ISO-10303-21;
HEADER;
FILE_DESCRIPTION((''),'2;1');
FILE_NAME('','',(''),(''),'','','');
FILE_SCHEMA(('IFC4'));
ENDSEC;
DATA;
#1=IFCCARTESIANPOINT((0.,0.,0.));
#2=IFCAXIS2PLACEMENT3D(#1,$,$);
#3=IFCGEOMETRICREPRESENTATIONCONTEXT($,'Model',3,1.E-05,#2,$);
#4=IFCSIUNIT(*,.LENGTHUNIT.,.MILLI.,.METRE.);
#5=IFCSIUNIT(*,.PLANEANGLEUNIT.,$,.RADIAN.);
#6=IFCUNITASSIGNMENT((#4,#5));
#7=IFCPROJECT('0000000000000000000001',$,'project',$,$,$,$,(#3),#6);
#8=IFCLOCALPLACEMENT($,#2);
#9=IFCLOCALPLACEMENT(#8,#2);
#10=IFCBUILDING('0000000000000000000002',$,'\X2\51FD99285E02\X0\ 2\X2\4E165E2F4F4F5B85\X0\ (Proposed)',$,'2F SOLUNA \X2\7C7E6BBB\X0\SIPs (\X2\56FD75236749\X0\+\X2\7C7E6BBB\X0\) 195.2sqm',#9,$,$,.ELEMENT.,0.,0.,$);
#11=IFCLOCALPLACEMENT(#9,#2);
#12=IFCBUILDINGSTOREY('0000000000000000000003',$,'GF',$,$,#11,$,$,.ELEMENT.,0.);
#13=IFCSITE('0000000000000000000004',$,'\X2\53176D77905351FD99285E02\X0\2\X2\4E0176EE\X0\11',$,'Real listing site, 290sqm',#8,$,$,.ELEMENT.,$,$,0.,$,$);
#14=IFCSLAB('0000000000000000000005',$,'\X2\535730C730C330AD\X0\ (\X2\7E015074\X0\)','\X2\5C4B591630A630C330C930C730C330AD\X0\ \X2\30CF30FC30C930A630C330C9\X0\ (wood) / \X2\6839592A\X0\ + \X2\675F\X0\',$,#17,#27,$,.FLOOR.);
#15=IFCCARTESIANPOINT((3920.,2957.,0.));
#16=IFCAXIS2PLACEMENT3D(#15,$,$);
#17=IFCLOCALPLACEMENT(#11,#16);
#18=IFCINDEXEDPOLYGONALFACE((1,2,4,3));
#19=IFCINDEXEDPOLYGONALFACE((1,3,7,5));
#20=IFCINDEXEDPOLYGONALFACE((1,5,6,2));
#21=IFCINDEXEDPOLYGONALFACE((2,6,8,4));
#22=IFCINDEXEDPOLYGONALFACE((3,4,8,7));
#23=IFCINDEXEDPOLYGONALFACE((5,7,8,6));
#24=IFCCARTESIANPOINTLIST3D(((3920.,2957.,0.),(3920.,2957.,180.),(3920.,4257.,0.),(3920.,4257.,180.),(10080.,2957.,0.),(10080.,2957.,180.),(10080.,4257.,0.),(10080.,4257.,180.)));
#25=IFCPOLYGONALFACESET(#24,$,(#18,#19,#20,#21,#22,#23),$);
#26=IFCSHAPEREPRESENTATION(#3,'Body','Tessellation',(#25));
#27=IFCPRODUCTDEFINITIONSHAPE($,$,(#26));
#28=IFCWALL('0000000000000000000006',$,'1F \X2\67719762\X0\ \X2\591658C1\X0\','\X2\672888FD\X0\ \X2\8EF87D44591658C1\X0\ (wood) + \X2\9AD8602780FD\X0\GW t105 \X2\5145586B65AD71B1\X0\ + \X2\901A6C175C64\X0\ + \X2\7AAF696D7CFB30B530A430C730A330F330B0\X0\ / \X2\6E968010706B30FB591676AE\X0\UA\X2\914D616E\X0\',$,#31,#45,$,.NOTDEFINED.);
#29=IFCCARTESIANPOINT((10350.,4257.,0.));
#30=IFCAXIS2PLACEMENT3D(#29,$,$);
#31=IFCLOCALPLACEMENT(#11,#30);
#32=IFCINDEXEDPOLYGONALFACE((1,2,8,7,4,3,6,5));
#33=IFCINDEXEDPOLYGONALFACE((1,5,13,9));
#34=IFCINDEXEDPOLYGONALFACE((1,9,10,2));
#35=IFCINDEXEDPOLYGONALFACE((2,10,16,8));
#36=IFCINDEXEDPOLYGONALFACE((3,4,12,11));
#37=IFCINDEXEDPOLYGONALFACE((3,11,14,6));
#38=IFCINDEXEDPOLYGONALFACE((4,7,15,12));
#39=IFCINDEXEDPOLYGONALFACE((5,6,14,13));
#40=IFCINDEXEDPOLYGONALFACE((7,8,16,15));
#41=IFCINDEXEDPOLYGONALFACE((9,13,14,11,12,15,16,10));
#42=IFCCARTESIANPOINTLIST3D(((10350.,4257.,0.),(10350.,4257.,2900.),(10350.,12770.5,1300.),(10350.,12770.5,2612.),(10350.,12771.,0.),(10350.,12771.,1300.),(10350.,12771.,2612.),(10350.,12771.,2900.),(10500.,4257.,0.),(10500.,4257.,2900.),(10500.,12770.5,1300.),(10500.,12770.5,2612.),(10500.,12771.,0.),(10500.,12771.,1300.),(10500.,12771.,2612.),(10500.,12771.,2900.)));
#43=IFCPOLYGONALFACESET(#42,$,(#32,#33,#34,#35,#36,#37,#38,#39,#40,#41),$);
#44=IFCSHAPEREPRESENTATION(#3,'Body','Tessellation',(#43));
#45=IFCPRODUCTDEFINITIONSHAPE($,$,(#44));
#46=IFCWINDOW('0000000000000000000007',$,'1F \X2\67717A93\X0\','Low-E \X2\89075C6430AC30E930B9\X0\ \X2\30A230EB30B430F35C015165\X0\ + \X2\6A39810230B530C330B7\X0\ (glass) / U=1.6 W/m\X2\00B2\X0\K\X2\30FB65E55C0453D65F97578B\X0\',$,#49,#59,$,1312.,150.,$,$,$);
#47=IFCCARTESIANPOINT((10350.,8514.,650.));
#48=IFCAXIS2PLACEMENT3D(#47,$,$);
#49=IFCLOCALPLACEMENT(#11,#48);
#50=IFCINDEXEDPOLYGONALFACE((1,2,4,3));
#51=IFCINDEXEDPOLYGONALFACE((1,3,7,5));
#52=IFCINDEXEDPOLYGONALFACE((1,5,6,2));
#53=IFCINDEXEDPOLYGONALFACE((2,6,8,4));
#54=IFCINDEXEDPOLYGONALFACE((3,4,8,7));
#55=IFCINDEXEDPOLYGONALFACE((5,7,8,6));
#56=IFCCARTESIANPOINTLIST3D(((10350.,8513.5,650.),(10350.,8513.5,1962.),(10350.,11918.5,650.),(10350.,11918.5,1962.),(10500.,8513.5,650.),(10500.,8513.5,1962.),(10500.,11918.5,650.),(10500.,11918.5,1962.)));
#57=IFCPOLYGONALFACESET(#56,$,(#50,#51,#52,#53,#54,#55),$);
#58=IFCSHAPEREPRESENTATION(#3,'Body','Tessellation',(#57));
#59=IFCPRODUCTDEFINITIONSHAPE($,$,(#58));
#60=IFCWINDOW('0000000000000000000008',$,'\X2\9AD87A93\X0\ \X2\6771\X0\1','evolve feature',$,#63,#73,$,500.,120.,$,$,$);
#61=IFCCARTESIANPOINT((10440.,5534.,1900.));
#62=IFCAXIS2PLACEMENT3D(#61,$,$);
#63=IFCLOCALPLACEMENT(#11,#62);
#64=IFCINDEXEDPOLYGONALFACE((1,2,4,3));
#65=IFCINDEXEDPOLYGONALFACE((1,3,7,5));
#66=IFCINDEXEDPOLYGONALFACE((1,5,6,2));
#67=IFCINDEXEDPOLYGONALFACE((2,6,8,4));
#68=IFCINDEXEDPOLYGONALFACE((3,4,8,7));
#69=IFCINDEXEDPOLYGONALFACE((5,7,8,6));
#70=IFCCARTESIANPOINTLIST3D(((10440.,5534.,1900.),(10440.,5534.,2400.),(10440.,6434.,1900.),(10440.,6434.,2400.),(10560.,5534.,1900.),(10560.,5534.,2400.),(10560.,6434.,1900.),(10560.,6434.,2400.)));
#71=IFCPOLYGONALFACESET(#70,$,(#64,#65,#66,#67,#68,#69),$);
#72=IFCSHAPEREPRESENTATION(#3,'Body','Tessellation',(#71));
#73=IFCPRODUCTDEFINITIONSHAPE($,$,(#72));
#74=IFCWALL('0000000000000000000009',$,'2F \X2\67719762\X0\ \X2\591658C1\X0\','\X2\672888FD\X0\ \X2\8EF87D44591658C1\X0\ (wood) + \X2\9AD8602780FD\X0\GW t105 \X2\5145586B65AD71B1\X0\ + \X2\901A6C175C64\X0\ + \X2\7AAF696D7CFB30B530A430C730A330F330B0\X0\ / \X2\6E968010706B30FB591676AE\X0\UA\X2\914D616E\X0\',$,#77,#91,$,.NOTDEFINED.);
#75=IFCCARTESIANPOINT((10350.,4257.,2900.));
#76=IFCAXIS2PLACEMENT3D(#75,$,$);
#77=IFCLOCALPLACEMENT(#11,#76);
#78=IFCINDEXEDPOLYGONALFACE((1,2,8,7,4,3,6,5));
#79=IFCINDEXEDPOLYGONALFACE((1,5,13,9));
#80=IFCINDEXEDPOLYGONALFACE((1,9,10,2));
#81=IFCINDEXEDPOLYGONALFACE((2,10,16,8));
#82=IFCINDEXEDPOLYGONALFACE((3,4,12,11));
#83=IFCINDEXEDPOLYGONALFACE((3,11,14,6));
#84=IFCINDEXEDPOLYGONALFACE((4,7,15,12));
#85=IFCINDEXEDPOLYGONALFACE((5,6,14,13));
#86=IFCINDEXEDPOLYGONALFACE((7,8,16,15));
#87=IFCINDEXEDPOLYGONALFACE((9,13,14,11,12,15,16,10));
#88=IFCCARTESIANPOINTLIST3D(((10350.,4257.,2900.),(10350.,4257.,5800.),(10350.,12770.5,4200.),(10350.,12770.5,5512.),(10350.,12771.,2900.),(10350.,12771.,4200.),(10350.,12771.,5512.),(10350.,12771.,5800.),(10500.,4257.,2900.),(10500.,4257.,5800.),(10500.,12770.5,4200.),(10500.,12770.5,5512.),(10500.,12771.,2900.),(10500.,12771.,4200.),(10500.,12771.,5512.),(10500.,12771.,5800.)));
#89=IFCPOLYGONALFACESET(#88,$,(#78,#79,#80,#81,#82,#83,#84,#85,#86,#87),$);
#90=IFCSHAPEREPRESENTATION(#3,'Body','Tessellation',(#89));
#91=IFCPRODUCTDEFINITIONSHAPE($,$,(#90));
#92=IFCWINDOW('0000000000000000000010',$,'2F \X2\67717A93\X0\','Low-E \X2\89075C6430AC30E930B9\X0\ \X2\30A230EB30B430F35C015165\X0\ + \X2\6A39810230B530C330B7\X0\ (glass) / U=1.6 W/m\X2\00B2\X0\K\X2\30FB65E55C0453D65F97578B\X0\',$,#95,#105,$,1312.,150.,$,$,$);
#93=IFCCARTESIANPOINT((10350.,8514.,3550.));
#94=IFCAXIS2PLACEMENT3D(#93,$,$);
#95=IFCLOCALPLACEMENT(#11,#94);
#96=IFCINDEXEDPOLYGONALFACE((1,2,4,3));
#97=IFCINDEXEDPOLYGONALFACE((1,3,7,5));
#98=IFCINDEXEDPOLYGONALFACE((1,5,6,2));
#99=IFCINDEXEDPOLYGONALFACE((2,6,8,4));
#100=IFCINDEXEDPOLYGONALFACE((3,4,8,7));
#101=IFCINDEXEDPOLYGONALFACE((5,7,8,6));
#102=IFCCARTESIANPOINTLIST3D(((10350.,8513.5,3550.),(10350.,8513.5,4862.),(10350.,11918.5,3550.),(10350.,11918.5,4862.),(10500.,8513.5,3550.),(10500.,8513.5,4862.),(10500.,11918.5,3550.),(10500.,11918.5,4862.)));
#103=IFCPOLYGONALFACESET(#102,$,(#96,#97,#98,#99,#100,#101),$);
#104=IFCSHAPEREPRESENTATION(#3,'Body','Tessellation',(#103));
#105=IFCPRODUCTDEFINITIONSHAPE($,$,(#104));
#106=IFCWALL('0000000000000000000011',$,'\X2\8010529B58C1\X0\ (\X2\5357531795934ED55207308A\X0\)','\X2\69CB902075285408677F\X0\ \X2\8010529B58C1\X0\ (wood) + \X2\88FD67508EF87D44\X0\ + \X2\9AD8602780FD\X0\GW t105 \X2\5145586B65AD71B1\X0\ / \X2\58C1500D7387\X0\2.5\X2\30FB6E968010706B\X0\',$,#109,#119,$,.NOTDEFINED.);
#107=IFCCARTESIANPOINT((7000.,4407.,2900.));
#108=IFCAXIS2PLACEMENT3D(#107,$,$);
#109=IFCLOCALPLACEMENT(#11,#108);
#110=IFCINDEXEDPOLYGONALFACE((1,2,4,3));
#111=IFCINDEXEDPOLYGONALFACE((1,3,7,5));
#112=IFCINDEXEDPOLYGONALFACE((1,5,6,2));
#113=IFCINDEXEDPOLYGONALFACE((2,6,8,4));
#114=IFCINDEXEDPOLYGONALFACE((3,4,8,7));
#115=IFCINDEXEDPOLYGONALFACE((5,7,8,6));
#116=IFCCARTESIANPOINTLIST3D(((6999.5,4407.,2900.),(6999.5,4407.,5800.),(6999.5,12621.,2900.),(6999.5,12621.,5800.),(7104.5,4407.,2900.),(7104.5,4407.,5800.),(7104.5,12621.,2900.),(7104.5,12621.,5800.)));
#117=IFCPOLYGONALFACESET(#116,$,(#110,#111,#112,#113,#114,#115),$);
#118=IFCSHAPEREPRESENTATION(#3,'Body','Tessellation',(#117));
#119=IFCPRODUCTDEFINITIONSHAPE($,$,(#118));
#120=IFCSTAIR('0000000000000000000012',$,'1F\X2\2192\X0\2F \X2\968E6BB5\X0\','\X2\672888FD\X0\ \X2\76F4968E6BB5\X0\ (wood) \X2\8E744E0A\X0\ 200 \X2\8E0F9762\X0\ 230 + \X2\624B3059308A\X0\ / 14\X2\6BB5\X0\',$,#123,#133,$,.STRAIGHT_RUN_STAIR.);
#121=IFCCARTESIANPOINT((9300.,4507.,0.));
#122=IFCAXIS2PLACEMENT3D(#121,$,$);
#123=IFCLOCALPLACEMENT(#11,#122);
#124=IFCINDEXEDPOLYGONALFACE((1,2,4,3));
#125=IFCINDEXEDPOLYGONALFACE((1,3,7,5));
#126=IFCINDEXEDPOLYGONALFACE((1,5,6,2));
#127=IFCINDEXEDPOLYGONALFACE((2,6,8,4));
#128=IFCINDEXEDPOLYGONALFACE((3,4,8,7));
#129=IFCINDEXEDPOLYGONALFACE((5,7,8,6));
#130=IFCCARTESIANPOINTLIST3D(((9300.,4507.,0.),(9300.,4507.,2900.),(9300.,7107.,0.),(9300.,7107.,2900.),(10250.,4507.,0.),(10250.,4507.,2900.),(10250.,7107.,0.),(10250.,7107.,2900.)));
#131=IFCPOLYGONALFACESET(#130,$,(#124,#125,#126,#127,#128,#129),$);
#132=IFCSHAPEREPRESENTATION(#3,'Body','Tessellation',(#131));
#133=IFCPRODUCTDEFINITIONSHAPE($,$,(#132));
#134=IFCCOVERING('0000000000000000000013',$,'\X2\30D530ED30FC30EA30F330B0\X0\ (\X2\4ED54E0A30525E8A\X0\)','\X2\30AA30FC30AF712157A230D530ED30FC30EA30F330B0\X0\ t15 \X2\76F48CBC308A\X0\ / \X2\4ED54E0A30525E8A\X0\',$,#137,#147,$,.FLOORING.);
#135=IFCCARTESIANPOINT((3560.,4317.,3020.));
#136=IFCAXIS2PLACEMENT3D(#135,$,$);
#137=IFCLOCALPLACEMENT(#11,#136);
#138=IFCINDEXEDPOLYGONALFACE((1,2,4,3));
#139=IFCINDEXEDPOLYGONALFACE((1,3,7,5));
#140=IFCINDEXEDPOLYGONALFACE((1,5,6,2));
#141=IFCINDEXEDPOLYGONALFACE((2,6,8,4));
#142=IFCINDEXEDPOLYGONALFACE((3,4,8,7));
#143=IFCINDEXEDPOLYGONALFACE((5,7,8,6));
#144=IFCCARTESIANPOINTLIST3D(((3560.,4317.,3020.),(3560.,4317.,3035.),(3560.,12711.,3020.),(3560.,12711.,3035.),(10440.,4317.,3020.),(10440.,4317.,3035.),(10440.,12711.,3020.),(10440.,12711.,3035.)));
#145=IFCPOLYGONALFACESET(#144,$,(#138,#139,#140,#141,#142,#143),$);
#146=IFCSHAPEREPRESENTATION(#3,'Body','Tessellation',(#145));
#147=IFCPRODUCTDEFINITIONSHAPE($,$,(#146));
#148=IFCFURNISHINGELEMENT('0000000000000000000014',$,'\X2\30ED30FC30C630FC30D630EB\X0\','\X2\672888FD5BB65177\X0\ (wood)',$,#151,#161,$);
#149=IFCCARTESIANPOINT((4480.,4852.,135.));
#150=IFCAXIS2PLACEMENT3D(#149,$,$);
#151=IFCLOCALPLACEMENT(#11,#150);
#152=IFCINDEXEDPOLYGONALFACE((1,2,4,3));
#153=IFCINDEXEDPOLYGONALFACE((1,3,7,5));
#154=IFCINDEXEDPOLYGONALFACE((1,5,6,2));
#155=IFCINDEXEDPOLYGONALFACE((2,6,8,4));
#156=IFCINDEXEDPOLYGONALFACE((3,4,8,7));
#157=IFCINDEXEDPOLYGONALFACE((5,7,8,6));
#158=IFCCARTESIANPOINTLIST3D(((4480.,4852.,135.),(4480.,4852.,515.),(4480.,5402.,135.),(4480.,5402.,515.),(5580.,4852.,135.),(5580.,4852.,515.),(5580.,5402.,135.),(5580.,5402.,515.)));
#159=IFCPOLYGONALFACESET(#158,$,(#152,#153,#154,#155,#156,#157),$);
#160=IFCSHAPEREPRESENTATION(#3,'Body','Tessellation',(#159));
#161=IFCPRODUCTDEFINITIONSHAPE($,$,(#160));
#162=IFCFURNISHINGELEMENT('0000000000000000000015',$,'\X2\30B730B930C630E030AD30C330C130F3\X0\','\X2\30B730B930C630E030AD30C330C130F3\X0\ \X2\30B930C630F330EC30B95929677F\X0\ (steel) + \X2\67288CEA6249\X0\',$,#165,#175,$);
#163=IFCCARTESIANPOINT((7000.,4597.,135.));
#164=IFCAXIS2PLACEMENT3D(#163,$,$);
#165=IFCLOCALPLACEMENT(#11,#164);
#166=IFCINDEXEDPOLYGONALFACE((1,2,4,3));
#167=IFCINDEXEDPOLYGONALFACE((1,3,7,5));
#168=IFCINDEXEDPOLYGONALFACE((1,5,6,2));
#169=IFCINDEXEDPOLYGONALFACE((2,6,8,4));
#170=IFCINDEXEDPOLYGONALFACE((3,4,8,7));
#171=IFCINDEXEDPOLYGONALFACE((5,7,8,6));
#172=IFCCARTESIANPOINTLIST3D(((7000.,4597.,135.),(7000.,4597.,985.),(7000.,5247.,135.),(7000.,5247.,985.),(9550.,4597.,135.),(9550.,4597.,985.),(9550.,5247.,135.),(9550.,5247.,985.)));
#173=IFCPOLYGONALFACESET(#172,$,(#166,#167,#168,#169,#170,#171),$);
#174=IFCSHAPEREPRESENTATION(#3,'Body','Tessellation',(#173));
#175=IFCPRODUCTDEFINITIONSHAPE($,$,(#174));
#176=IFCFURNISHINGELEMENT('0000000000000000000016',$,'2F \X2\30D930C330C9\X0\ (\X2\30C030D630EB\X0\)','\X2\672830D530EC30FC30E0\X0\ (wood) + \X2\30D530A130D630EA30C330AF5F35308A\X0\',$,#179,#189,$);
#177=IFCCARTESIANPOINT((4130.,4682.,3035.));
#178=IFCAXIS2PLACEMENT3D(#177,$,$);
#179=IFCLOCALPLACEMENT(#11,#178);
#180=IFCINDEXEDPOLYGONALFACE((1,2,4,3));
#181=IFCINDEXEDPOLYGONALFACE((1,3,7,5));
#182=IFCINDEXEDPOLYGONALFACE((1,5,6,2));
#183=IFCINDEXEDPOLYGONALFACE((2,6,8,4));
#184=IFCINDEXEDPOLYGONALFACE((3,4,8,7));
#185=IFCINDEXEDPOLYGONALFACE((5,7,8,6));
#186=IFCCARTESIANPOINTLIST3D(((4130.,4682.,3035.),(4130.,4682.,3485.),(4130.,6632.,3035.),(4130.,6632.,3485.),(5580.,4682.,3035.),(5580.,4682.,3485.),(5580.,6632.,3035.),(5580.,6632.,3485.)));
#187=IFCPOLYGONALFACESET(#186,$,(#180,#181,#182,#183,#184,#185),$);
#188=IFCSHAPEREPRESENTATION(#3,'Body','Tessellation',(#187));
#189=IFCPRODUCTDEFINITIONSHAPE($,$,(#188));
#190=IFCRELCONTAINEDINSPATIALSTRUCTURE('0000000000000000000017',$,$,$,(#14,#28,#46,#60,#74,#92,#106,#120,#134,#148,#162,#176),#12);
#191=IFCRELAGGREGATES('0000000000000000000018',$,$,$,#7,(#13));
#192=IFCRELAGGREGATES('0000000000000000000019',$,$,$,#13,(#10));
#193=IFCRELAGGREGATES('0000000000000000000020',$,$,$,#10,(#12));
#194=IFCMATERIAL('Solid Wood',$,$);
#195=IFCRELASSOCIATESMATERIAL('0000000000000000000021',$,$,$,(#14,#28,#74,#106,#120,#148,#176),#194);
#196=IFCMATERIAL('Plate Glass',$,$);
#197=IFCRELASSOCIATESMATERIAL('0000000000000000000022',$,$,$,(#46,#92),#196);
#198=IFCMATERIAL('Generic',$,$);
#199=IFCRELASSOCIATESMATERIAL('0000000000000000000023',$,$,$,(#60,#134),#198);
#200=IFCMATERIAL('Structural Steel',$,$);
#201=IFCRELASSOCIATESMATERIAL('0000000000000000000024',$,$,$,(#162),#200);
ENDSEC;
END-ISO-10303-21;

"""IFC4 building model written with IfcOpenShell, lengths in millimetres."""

from ifc_helpers import new_model, si_unit, frame, frame_2d, origin, place, context, project, spatial, rectangle, extrude, material, element, fill, save


model = new_model("IFC4")

# Units and contexts
model_context = context("Model", 3, precision=1e-05, world=origin())
ifc_project = project(units=[si_unit("LENGTHUNIT", "METRE", prefix="MILLI"), si_unit("PLANEANGLEUNIT", "RADIAN")], contexts=[model_context])

# Site, building, storey
site_placement = place(None, origin())
site = spatial("IfcSite", under=ifc_project, at=site_placement, Name="北海道函館市2丁目11", ObjectType="Real listing site, 290sqm", CompositionType="ELEMENT", RefElevation=0.0)
building_placement = place(site_placement, origin())
building = spatial("IfcBuilding", under=site, at=building_placement, Name="函館市 2世帯住宅 (Proposed)", ObjectType="2F SOLUNA 籾殻SIPs (国産杉+籾殻) 195.2sqm", CompositionType="ELEMENT", ElevationOfRefHeight=0.0, ElevationOfTerrain=0.0)
storey_placement = place(building_placement, origin())
storey = spatial("IfcBuildingStorey", under=building, at=storey_placement, Name="GF", CompositionType="ELEMENT", Elevation=0.0)

# Slab
ifc_material_1 = material(Name="Solid Wood")
slab_placement = place(storey_placement, frame((3920.0, 2957.0, 0.0)))
element("IfcSlab", 1, at=slab_placement, inside=storey, material=ifc_material_1, Name="南デッキ (縁側)", Description="屋外ウッドデッキ ハードウッド (wood) / 根太 + 束", PredefinedType="FLOOR", context=model_context, shape_type="SweptSolid", body=[
    extrude(rectangle(XDim=6160.0, YDim=1300.0, at=frame_2d((3080.0, 650.0))), frame((3920.0, 2957.0, 0.0)), (0.0, 0.0, 1.0), 180.0),
])

# Wall, openings, windows
wall_1_placement = place(storey_placement, frame((10350.0, 4257.0, 0.0)))
wall_1 = element("IfcWall", 2, at=wall_1_placement, inside=storey, material=ifc_material_1, Name="1F 東面 外壁", Description="木製 軸組外壁 (wood) + 高性能GW t105 充填断熱 + 通気層 + 窯業系サイディング / 準耐火・外皮UA配慮", PredefinedType="NOTDEFINED", context=model_context, shape_type="SweptSolid", body=[
    extrude(rectangle(XDim=150.0, YDim=8514.0, at=frame_2d((75.0, 4257.0))), frame((10350.0, 4257.0, 0.0)), (0.0, 0.0, 1.0), 2900.0),
])
opening_1_placement = place(storey_placement, frame((10350.0, 8514.0, 650.0)))
opening_1 = element("IfcOpeningElement", 3, at=opening_1_placement, cuts=wall_1, PredefinedType="NOTDEFINED", context=model_context, shape_type="SweptSolid", body=[
    extrude(rectangle(XDim=150.0, YDim=3405.0, at=frame_2d((75.0, 1702.0))), frame((10350.0, 8514.0, 650.0)), (0.0, 0.0, 1.0), 1312.0),
])
opening_2_placement = place(storey_placement, frame((10440.0, 5534.0, 1900.0)))
opening_2 = element("IfcOpeningElement", 4, at=opening_2_placement, cuts=wall_1, PredefinedType="NOTDEFINED", context=model_context, shape_type="SweptSolid", body=[
    extrude(rectangle(XDim=120.0, YDim=900.0, at=frame_2d((60.0, 450.0))), frame((10440.0, 5534.0, 1900.0)), (0.0, 0.0, 1.0), 500.0),
])
ifc_material_2 = material(Name="Plate Glass")
window_1_placement = place(storey_placement, frame((10350.0, 8514.0, 650.0)))
window_1 = element("IfcWindow", 5, at=window_1_placement, inside=storey, material=ifc_material_2, Name="1F 東窓", Description="Low-E 複層ガラス アルゴン封入 + 樹脂サッシ (glass) / U=1.6 W/m²K・日射取得型", OverallHeight=1312.0, OverallWidth=150.0, context=model_context, shape_type="SweptSolid", body=[
    extrude(rectangle(XDim=150.0, YDim=3405.0, at=frame_2d((75.0, 1702.0))), frame((10350.0, 8514.0, 650.0)), (0.0, 0.0, 1.0), 1312.0),
])
fill(opening_1, window_1)
ifc_material_3 = material(Name="Generic")
window_2_placement = place(storey_placement, frame((10440.0, 5534.0, 1900.0)))
window_2 = element("IfcWindow", 6, at=window_2_placement, inside=storey, material=ifc_material_3, Name="高窓 東1", Description="evolve feature", OverallHeight=500.0, OverallWidth=120.0, context=model_context, shape_type="SweptSolid", body=[
    extrude(rectangle(XDim=120.0, YDim=900.0, at=frame_2d((60.0, 450.0))), frame((10440.0, 5534.0, 1900.0)), (0.0, 0.0, 1.0), 500.0),
])
fill(opening_2, window_2)

# Wall, opening, window
wall_2_placement = place(storey_placement, frame((10350.0, 4257.0, 2900.0)))
wall_2 = element("IfcWall", 7, at=wall_2_placement, inside=storey, material=ifc_material_1, Name="2F 東面 外壁", Description="木製 軸組外壁 (wood) + 高性能GW t105 充填断熱 + 通気層 + 窯業系サイディング / 準耐火・外皮UA配慮", PredefinedType="NOTDEFINED", context=model_context, shape_type="SweptSolid", body=[
    extrude(rectangle(XDim=150.0, YDim=8514.0, at=frame_2d((75.0, 4257.0))), frame((10350.0, 4257.0, 2900.0)), (0.0, 0.0, 1.0), 2900.0),
])
opening_3_placement = place(storey_placement, frame((10350.0, 8514.0, 3550.0)))
opening_3 = element("IfcOpeningElement", 8, at=opening_3_placement, cuts=wall_2, PredefinedType="NOTDEFINED", context=model_context, shape_type="SweptSolid", body=[
    extrude(rectangle(XDim=150.0, YDim=3405.0, at=frame_2d((75.0, 1702.0))), frame((10350.0, 8514.0, 3550.0)), (0.0, 0.0, 1.0), 1312.0),
])
window_3_placement = place(storey_placement, frame((10350.0, 8514.0, 3550.0)))
window_3 = element("IfcWindow", 9, at=window_3_placement, inside=storey, material=ifc_material_2, Name="2F 東窓", Description="Low-E 複層ガラス アルゴン封入 + 樹脂サッシ (glass) / U=1.6 W/m²K・日射取得型", OverallHeight=1312.0, OverallWidth=150.0, context=model_context, shape_type="SweptSolid", body=[
    extrude(rectangle(XDim=150.0, YDim=3405.0, at=frame_2d((75.0, 1702.0))), frame((10350.0, 8514.0, 3550.0)), (0.0, 0.0, 1.0), 1312.0),
])
fill(opening_3, window_3)

# Wall
wall_3_placement = place(storey_placement, frame((7000.0, 4407.0, 2900.0)))
element("IfcWall", 10, at=wall_3_placement, inside=storey, material=ifc_material_1, Name="耐力壁 (南北間仕切り)", Description="構造用合板 耐力壁 (wood) + 製材軸組 + 高性能GW t105 充填断熱 / 壁倍率2.5・準耐火", PredefinedType="NOTDEFINED", context=model_context, shape_type="SweptSolid", body=[
    extrude(rectangle(XDim=105.0, YDim=8214.0, at=frame_2d((52.0, 4107.0))), frame((7000.0, 4407.0, 2900.0)), (0.0, 0.0, 1.0), 2900.0),
])

# Stair
stair_placement = place(storey_placement, frame((9300.0, 4507.0, 0.0)))
element("IfcStair", 11, at=stair_placement, inside=storey, material=ifc_material_1, Name="1F→2F 階段", Description="木製 直階段 (wood) 蹴上 200 踏面 230 + 手すり / 14段", PredefinedType="STRAIGHT_RUN_STAIR", context=model_context, shape_type="SweptSolid", body=[
    extrude(rectangle(XDim=950.0, YDim=2600.0, at=frame_2d((475.0, 1300.0))), frame((9300.0, 4507.0, 0.0)), (0.0, 0.0, 1.0), 2900.0),
])

# Covering
covering_placement = place(storey_placement, frame((3560.0, 4317.0, 3020.0)))
element("IfcCovering", 12, at=covering_placement, inside=storey, material=ifc_material_3, Name="フローリング (仕上げ床)", Description="オーク無垢フローリング t15 直貼り / 仕上げ床", PredefinedType="FLOORING", context=model_context, shape_type="SweptSolid", body=[
    extrude(rectangle(XDim=6880.0, YDim=8394.0, at=frame_2d((3440.0, 4197.0))), frame((3560.0, 4317.0, 3020.0)), (0.0, 0.0, 1.0), 15.0),
])

# Furnishing elements
furnishing_1_placement = place(storey_placement, frame((4480.0, 4852.0, 135.0)))
element("IfcFurnishingElement", 13, at=furnishing_1_placement, inside=storey, material=ifc_material_1, Name="ローテーブル", Description="木製家具 (wood)", context=model_context, shape_type="SweptSolid", body=[
    extrude(rectangle(XDim=1100.0, YDim=550.0, at=frame_2d((550.0, 275.0))), frame((4480.0, 4852.0, 135.0)), (0.0, 0.0, 1.0), 380.0),
])
ifc_material_4 = material(Name="Structural Steel")
furnishing_2_placement = place(storey_placement, frame((7000.0, 4597.0, 135.0)))
element("IfcFurnishingElement", 14, at=furnishing_2_placement, inside=storey, material=ifc_material_4, Name="システムキッチン", Description="システムキッチン ステンレス天板 (steel) + 木質扉", context=model_context, shape_type="SweptSolid", body=[
    extrude(rectangle(XDim=2550.0, YDim=650.0, at=frame_2d((1275.0, 325.0))), frame((7000.0, 4597.0, 135.0)), (0.0, 0.0, 1.0), 850.0),
])
furnishing_3_placement = place(storey_placement, frame((4130.0, 4682.0, 3035.0)))
element("IfcFurnishingElement", 15, at=furnishing_3_placement, inside=storey, material=ifc_material_1, Name="2F ベッド (ダブル)", Description="木フレーム (wood) + ファブリック張り", context=model_context, shape_type="SweptSolid", body=[
    extrude(rectangle(XDim=1450.0, YDim=1950.0, at=frame_2d((725.0, 975.0))), frame((4130.0, 4682.0, 3035.0)), (0.0, 0.0, 1.0), 450.0),
])

save(model, "model.ifc")
